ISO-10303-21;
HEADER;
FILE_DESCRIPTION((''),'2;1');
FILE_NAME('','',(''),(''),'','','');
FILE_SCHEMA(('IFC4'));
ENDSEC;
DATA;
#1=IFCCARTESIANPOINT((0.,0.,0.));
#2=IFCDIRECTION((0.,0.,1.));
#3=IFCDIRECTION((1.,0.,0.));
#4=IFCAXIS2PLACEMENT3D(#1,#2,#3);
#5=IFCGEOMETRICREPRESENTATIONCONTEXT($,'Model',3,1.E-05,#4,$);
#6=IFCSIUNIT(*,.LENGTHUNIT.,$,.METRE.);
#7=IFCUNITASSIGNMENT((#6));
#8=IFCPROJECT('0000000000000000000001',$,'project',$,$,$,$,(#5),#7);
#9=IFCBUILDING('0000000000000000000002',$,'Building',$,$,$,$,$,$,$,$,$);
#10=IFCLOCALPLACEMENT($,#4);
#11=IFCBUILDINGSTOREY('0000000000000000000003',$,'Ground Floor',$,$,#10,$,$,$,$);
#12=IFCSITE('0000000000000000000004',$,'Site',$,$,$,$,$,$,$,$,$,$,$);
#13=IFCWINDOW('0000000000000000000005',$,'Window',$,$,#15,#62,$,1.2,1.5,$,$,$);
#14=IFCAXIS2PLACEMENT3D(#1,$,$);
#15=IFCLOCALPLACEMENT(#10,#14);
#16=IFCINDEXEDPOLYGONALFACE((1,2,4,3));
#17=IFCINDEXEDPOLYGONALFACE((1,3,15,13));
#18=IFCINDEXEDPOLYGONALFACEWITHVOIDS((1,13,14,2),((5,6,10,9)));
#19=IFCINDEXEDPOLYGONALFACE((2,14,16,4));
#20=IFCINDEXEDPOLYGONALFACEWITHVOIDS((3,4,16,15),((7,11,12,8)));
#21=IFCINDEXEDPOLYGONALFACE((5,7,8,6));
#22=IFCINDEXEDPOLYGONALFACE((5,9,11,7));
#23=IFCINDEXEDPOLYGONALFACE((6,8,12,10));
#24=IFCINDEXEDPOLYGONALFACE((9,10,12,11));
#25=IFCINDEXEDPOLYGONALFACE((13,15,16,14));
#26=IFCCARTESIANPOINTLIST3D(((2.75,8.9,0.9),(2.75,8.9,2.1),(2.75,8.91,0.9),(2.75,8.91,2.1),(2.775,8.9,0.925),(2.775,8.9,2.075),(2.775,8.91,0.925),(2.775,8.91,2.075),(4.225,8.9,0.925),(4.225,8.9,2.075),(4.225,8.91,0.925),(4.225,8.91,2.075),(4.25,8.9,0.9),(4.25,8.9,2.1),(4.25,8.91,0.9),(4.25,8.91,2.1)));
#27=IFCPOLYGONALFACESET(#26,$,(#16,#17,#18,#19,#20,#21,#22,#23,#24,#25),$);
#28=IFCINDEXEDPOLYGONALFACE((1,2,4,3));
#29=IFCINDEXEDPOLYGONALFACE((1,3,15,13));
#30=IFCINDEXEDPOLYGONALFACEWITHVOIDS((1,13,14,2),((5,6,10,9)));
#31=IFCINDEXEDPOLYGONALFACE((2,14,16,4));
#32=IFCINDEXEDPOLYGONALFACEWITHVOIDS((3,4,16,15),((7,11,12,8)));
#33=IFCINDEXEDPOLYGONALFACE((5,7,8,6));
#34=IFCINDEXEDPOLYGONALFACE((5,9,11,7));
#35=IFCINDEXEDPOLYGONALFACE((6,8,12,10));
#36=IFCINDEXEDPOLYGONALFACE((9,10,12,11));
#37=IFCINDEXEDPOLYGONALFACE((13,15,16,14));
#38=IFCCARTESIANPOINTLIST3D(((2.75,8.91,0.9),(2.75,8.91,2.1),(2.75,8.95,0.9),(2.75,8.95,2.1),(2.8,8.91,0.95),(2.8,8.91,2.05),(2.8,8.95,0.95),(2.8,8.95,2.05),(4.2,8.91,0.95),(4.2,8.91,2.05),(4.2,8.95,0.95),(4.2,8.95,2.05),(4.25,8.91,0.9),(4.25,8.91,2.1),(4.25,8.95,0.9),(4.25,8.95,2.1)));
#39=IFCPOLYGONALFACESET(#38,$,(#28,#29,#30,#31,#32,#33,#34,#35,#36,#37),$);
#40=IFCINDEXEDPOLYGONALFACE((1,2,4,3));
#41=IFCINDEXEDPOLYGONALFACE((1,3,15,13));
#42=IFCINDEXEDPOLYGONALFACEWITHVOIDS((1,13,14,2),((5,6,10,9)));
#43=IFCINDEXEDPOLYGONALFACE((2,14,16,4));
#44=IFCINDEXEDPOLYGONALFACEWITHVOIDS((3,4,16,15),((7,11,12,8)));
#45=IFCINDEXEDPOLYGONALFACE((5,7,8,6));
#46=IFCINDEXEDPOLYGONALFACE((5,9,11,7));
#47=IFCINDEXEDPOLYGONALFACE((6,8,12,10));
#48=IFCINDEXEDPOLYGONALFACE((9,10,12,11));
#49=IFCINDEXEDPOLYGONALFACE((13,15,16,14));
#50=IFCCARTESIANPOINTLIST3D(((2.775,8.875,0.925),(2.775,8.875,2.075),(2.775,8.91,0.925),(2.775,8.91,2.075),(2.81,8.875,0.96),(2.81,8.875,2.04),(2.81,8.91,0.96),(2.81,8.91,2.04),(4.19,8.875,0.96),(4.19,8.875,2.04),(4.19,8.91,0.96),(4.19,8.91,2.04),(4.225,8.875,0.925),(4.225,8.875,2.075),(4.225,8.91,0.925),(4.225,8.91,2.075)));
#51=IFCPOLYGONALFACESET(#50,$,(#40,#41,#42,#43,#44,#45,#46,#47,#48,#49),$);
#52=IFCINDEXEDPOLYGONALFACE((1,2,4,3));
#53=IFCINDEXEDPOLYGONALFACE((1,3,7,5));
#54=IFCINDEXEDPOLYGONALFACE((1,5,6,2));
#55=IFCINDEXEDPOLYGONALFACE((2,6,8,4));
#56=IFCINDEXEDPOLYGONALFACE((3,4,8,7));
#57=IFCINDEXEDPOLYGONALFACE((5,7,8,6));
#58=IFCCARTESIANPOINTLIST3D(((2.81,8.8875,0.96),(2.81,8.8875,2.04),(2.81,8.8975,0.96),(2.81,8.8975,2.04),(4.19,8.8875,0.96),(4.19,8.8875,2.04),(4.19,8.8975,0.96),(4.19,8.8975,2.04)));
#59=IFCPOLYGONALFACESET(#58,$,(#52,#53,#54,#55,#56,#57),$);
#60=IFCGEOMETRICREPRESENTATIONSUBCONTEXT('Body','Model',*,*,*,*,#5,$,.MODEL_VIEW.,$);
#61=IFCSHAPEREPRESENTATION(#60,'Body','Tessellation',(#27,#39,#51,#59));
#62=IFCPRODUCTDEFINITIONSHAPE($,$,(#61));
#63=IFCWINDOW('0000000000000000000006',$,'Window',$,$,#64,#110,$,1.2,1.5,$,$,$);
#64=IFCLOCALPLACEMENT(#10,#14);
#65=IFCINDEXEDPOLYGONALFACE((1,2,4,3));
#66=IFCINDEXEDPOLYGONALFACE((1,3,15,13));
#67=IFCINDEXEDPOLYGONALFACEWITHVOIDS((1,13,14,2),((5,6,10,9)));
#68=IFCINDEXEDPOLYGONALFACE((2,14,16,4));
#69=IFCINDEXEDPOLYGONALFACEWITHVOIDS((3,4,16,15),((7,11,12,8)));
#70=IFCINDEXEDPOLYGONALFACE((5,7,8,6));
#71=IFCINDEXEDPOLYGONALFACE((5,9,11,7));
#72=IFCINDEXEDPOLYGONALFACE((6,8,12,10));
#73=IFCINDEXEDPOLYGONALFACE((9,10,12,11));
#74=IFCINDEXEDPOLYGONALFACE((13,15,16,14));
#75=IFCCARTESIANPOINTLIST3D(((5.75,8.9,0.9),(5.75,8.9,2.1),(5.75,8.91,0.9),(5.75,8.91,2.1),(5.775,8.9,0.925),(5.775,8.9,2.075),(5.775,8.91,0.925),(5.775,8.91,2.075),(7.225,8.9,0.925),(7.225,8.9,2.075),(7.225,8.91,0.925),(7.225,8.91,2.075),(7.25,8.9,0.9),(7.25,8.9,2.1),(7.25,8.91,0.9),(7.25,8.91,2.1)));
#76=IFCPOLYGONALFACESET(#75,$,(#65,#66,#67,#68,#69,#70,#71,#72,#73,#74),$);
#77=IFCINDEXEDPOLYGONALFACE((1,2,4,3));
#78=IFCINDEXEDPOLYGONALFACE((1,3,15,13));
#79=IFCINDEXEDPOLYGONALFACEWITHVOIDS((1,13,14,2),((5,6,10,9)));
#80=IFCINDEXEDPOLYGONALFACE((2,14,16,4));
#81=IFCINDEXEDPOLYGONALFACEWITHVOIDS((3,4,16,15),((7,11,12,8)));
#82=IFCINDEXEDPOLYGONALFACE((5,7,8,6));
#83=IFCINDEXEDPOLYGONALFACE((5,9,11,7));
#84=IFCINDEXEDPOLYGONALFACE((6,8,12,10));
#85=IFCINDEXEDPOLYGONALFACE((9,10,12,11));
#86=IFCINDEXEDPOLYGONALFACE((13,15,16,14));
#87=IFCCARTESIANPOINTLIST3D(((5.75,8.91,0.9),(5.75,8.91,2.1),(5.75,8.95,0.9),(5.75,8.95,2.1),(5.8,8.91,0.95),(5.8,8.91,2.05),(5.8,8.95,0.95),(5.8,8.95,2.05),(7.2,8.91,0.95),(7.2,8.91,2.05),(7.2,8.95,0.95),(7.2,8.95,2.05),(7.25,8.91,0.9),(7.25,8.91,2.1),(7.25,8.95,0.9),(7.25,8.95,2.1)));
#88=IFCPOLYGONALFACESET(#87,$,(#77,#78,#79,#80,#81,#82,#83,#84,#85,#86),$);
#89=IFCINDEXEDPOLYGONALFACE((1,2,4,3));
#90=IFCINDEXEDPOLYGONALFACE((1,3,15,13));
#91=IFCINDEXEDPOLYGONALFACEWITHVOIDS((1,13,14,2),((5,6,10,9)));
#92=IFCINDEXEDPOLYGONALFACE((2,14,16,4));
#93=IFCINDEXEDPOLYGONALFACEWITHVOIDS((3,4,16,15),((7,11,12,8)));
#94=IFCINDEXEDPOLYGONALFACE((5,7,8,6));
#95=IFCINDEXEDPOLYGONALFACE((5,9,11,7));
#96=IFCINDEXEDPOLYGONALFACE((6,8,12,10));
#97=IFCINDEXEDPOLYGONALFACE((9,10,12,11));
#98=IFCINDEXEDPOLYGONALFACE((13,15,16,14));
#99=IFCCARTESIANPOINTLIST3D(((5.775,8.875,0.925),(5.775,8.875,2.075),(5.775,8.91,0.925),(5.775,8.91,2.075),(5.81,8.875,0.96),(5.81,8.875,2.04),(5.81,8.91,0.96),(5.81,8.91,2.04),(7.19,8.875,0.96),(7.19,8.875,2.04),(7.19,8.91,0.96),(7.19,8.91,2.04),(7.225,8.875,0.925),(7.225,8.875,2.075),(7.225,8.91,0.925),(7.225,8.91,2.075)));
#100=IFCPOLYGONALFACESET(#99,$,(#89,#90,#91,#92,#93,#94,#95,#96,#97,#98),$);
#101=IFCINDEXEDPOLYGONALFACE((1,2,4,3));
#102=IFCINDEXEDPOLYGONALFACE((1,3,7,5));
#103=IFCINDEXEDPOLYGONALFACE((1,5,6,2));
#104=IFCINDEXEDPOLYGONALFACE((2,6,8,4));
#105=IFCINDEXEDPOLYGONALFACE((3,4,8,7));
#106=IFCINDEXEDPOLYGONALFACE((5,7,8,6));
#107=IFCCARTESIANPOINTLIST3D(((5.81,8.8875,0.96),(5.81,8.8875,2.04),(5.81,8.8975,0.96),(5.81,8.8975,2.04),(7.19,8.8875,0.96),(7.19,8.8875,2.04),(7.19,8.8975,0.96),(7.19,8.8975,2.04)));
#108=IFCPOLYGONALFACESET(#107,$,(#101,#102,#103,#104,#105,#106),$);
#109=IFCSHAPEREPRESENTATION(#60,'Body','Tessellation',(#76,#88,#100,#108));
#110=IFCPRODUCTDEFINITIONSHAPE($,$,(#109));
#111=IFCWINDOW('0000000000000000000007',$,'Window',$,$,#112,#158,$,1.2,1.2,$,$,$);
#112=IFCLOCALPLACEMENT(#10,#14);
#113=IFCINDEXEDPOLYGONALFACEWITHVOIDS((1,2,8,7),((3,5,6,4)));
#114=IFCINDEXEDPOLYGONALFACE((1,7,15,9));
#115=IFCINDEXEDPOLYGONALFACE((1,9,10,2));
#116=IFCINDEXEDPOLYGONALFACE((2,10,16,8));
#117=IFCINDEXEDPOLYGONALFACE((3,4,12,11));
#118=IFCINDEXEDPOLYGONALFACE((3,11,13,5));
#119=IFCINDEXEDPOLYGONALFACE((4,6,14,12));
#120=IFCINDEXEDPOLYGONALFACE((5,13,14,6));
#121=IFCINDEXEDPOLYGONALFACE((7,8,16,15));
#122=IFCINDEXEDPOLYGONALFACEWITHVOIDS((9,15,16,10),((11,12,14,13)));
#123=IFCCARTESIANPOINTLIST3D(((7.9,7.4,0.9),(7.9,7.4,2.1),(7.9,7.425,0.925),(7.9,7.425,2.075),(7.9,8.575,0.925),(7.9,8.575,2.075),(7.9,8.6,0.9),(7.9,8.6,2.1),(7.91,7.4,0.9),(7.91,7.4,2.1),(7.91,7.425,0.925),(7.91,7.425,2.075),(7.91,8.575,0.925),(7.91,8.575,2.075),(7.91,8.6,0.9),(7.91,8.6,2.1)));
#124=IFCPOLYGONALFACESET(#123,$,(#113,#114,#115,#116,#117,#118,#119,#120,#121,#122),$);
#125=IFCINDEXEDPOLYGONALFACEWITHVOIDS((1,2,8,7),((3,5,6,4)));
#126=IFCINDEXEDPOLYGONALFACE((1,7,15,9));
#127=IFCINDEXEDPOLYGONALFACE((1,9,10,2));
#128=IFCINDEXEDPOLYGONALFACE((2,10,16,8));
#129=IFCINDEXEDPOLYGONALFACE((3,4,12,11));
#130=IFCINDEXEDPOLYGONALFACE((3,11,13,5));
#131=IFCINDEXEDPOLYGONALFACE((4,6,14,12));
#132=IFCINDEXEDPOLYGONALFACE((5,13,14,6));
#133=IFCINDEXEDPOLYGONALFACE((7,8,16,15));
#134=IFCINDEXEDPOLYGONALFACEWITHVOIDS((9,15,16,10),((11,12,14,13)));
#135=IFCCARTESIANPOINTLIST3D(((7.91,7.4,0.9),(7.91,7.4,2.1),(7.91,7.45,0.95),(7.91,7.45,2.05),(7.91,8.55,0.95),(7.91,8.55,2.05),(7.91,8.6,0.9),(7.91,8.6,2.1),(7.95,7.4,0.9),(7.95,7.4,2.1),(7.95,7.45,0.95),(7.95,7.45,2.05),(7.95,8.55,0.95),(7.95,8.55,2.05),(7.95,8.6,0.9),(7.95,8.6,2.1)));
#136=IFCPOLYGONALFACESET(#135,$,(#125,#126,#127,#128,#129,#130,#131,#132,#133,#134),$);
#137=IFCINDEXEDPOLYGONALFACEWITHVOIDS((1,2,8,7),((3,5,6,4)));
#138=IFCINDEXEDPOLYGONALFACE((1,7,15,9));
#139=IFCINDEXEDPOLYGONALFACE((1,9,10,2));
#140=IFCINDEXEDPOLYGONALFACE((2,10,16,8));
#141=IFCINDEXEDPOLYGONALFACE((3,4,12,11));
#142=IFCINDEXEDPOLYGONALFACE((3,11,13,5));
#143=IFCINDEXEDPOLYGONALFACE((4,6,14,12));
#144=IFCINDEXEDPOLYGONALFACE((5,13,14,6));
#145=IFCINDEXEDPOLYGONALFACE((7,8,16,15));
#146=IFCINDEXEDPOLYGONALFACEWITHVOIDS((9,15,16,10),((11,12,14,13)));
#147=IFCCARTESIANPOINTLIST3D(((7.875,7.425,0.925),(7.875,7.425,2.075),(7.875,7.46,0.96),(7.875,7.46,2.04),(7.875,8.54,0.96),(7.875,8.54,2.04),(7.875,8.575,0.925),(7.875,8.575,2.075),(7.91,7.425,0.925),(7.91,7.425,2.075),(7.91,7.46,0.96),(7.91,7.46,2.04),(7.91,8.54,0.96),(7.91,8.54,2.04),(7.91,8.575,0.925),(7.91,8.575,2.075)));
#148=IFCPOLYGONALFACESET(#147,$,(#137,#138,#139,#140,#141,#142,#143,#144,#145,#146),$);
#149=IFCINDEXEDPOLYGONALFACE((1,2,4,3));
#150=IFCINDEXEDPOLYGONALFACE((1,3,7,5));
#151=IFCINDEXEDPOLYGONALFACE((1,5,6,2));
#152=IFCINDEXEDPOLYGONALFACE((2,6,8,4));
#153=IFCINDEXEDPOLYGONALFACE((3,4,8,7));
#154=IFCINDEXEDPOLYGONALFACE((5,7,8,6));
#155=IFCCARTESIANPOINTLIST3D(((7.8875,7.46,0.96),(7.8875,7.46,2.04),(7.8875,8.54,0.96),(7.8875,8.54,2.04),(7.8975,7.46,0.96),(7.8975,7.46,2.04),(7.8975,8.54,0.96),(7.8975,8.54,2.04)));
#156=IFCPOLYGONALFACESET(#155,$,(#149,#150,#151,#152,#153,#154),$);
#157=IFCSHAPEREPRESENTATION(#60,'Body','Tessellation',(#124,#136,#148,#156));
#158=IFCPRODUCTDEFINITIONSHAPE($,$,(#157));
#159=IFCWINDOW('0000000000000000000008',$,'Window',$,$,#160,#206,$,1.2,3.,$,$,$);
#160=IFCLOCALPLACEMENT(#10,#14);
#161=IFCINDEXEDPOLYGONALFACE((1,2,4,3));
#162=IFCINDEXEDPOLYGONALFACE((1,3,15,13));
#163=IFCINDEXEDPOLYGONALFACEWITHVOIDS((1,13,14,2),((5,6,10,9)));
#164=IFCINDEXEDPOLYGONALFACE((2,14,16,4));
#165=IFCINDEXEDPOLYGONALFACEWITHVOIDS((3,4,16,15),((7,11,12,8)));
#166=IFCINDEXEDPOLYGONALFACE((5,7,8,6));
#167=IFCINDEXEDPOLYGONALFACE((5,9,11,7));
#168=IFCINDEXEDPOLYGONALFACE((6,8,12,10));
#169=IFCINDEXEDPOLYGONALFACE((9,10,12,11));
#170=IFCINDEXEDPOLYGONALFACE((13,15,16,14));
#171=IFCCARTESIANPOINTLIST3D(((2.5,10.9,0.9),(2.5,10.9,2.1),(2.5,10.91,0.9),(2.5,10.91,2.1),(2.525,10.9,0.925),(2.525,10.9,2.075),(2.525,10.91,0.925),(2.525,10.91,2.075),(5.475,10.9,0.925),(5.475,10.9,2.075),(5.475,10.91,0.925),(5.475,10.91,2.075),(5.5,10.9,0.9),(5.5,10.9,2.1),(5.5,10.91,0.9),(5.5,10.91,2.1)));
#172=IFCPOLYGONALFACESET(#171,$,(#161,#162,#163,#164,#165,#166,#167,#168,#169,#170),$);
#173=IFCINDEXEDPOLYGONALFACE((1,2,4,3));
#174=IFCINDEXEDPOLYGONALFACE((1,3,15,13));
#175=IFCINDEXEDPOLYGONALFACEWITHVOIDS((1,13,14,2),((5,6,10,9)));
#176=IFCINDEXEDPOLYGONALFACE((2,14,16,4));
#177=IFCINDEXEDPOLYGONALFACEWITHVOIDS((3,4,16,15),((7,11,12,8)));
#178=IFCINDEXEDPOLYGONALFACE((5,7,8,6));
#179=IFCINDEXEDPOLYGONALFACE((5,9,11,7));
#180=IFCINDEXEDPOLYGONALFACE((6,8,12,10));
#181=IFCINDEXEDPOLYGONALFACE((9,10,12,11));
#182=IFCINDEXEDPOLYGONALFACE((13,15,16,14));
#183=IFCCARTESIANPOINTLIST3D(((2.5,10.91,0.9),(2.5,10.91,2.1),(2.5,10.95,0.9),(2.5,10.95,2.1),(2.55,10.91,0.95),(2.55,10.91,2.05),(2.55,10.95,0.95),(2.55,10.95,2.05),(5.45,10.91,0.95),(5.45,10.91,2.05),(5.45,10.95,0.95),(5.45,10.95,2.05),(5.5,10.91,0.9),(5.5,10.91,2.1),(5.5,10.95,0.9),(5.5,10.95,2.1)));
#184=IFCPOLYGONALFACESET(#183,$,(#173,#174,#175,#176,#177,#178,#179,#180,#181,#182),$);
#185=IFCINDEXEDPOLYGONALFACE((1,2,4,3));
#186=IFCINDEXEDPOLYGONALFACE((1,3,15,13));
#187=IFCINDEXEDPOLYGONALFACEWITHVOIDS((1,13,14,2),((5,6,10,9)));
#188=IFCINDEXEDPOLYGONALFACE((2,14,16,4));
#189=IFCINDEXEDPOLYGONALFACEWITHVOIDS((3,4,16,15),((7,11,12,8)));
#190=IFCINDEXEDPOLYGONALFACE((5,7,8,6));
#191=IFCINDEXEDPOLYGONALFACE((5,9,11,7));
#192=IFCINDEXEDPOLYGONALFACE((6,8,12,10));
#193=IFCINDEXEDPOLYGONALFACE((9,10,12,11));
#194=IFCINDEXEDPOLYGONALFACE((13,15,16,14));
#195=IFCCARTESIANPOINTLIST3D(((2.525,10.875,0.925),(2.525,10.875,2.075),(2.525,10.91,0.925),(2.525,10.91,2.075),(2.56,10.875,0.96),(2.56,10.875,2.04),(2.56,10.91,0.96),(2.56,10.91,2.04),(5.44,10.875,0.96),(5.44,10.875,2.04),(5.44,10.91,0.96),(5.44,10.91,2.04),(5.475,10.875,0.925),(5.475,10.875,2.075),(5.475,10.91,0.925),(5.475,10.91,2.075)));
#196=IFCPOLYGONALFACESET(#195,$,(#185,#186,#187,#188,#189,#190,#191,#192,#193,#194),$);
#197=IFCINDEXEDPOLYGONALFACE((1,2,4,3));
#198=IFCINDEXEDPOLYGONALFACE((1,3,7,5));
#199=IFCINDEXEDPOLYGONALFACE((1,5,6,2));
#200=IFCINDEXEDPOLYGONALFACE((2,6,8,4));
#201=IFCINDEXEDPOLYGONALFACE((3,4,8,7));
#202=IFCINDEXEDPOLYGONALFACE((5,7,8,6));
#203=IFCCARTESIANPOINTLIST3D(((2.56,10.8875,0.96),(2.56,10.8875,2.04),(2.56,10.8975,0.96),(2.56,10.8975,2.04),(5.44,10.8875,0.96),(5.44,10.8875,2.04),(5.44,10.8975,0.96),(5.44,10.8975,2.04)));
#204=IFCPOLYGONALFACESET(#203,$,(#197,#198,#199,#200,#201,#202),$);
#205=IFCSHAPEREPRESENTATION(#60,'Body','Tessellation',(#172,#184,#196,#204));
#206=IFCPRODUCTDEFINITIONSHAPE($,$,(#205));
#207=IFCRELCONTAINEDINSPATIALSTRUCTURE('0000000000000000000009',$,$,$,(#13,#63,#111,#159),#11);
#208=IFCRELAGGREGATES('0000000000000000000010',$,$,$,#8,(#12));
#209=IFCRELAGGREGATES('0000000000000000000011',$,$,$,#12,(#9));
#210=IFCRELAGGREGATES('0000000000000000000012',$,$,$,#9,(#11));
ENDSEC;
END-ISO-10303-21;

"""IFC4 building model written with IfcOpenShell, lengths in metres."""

from ifc_helpers import new_model, si_unit, frame, origin_with_axes, place, context, subcontext, project, spatial, line, indexed_curve, outline, extrude, element, save


model = new_model("IFC4")

# Units and contexts
model_context = context("Model", 3, precision=1e-05, world=origin_with_axes())
body_context = subcontext(model_context, "Body", "Model", "MODEL_VIEW")
ifc_project = project(units=[si_unit("LENGTHUNIT", "METRE")], contexts=[model_context])

# Site, building, storey
site = spatial("IfcSite", under=ifc_project, Name="Site")
building = spatial("IfcBuilding", under=site, Name="Building")
storey_placement = place(None, origin_with_axes())
storey = spatial("IfcBuildingStorey", under=building, at=storey_placement, Name="Ground Floor")

# Windows
for number, where, z_axis, x_axis, name in (
    (1, (4.25, 9.0, 0.9), (0.0, 0.0, 1.0), (-1.0, 0.0, 0.0), "Window"),
    (2, (7.25, 9.0, 0.9), (0.0, 0.0, 1.0), (-1.0, 0.0, 0.0), "Window"),
):
    element("IfcWindow", number, at=place(storey_placement, frame(where, z_axis=z_axis, x_axis=x_axis)), inside=storey, Name=name, OverallHeight=1.2, OverallWidth=1.5, context=body_context, shape_type="SweptSolid", body=[
        extrude(outline(indexed_curve([(0.0, 0.0), (1.5, 0.0), (1.5, 1.2), (0.0, 1.2)], segments=[line(1, 2, 3, 4, 1)]), holes=[indexed_curve([(0.025, 0.025), (1.475, 0.025), (1.475, 1.175), (0.025, 1.175)], segments=[line(1, 2, 3, 4, 1)])]), frame((0.0, 0.09, 0.0), z_axis=(0.0, -1.0, 0.0), x_axis=(1.0, 0.0, 0.0)), (0.0, 0.0, -1.0), 0.01),
        extrude(outline(indexed_curve([(0.0, 0.0), (1.5, 0.0), (1.5, 1.2), (0.0, 1.2)], segments=[line(1, 2, 3, 4, 1)]), holes=[indexed_curve([(0.05, 0.05), (1.45, 0.05), (1.45, 1.15), (0.05, 1.15)], segments=[line(1, 2, 3, 4, 1)])]), frame((0.0, 0.05, 0.0), z_axis=(0.0, -1.0, 0.0), x_axis=(1.0, 0.0, 0.0)), (0.0, 0.0, -1.0), 0.04),
        extrude(outline(indexed_curve([(0.0, 0.0), (1.45, 0.0), (1.45, 1.15), (0.0, 1.15)], segments=[line(1, 2, 3, 4, 1)]), holes=[indexed_curve([(0.035, 0.035), (1.415, 0.035), (1.415, 1.115), (0.035, 1.115)], segments=[line(1, 2, 3, 4, 1)])]), frame((0.025, 0.09, 0.025), z_axis=(0.0, -1.0, 0.0), x_axis=(1.0, 0.0, 0.0)), (0.0, 0.0, -1.0), 0.035),
        extrude(outline(indexed_curve([(0.035, 0.035), (1.415, 0.035), (1.415, 1.115), (0.035, 1.115)], segments=[line(1, 2, 3, 4, 1)])), frame((0.025, 0.1025, 0.025), z_axis=(0.0, -1.0, 0.0), x_axis=(1.0, 0.0, 0.0)), (0.0, 0.0, -1.0), 0.01),
    ])
window_1_placement = place(storey_placement, frame((8.0, 7.4, 0.9), z_axis=(0.0, 0.0, 1.0), x_axis=(0.0, 1.0, 0.0)))
element("IfcWindow", 3, at=window_1_placement, inside=storey, Name="Window", OverallHeight=1.2, OverallWidth=1.2, context=body_context, shape_type="SweptSolid", body=[
    extrude(outline(indexed_curve([(0.0, 0.0), (1.2, 0.0), (1.2, 1.2), (0.0, 1.2)], segments=[line(1, 2, 3, 4, 1)]), holes=[indexed_curve([(0.025, 0.025), (1.175, 0.025), (1.175, 1.175), (0.025, 1.175)], segments=[line(1, 2, 3, 4, 1)])]), frame((0.0, 0.09, 0.0), z_axis=(0.0, -1.0, 0.0), x_axis=(1.0, 0.0, 0.0)), (0.0, 0.0, -1.0), 0.01),
    extrude(outline(indexed_curve([(0.0, 0.0), (1.2, 0.0), (1.2, 1.2), (0.0, 1.2)], segments=[line(1, 2, 3, 4, 1)]), holes=[indexed_curve([(0.05, 0.05), (1.15, 0.05), (1.15, 1.15), (0.05, 1.15)], segments=[line(1, 2, 3, 4, 1)])]), frame((0.0, 0.05, 0.0), z_axis=(0.0, -1.0, 0.0), x_axis=(1.0, 0.0, 0.0)), (0.0, 0.0, -1.0), 0.04),
    extrude(outline(indexed_curve([(0.0, 0.0), (1.15, 0.0), (1.15, 1.15), (0.0, 1.15)], segments=[line(1, 2, 3, 4, 1)]), holes=[indexed_curve([(0.035, 0.035), (1.115, 0.035), (1.115, 1.115), (0.035, 1.115)], segments=[line(1, 2, 3, 4, 1)])]), frame((0.025, 0.09, 0.025), z_axis=(0.0, -1.0, 0.0), x_axis=(1.0, 0.0, 0.0)), (0.0, 0.0, -1.0), 0.035),
    extrude(outline(indexed_curve([(0.035, 0.035), (1.115, 0.035), (1.115, 1.115), (0.035, 1.115)], segments=[line(1, 2, 3, 4, 1)])), frame((0.025, 0.1025, 0.025), z_axis=(0.0, -1.0, 0.0), x_axis=(1.0, 0.0, 0.0)), (0.0, 0.0, -1.0), 0.01),
])
window_2_placement = place(storey_placement, frame((5.5, 11.0, 0.9), z_axis=(0.0, 0.0, 1.0), x_axis=(-1.0, 0.0, 0.0)))
element("IfcWindow", 4, at=window_2_placement, inside=storey, Name="Window", OverallHeight=1.2, OverallWidth=3.0, context=body_context, shape_type="SweptSolid", body=[
    extrude(outline(indexed_curve([(0.0, 0.0), (3.0, 0.0), (3.0, 1.2), (0.0, 1.2)], segments=[line(1, 2, 3, 4, 1)]), holes=[indexed_curve([(0.025, 0.025), (2.975, 0.025), (2.975, 1.175), (0.025, 1.175)], segments=[line(1, 2, 3, 4, 1)])]), frame((0.0, 0.09, 0.0), z_axis=(0.0, -1.0, 0.0), x_axis=(1.0, 0.0, 0.0)), (0.0, 0.0, -1.0), 0.01),
    extrude(outline(indexed_curve([(0.0, 0.0), (3.0, 0.0), (3.0, 1.2), (0.0, 1.2)], segments=[line(1, 2, 3, 4, 1)]), holes=[indexed_curve([(0.05, 0.05), (2.95, 0.05), (2.95, 1.15), (0.05, 1.15)], segments=[line(1, 2, 3, 4, 1)])]), frame((0.0, 0.05, 0.0), z_axis=(0.0, -1.0, 0.0), x_axis=(1.0, 0.0, 0.0)), (0.0, 0.0, -1.0), 0.04),
    extrude(outline(indexed_curve([(0.0, 0.0), (2.95, 0.0), (2.95, 1.15), (0.0, 1.15)], segments=[line(1, 2, 3, 4, 1)]), holes=[indexed_curve([(0.035, 0.035), (2.915, 0.035), (2.915, 1.115), (0.035, 1.115)], segments=[line(1, 2, 3, 4, 1)])]), frame((0.025, 0.09, 0.025), z_axis=(0.0, -1.0, 0.0), x_axis=(1.0, 0.0, 0.0)), (0.0, 0.0, -1.0), 0.035),
    extrude(outline(indexed_curve([(0.035, 0.035), (2.915, 0.035), (2.915, 1.115), (0.035, 1.115)], segments=[line(1, 2, 3, 4, 1)])), frame((0.025, 0.1025, 0.025), z_axis=(0.0, -1.0, 0.0), x_axis=(1.0, 0.0, 0.0)), (0.0, 0.0, -1.0), 0.01),
])

save(model, "model.ifc")
